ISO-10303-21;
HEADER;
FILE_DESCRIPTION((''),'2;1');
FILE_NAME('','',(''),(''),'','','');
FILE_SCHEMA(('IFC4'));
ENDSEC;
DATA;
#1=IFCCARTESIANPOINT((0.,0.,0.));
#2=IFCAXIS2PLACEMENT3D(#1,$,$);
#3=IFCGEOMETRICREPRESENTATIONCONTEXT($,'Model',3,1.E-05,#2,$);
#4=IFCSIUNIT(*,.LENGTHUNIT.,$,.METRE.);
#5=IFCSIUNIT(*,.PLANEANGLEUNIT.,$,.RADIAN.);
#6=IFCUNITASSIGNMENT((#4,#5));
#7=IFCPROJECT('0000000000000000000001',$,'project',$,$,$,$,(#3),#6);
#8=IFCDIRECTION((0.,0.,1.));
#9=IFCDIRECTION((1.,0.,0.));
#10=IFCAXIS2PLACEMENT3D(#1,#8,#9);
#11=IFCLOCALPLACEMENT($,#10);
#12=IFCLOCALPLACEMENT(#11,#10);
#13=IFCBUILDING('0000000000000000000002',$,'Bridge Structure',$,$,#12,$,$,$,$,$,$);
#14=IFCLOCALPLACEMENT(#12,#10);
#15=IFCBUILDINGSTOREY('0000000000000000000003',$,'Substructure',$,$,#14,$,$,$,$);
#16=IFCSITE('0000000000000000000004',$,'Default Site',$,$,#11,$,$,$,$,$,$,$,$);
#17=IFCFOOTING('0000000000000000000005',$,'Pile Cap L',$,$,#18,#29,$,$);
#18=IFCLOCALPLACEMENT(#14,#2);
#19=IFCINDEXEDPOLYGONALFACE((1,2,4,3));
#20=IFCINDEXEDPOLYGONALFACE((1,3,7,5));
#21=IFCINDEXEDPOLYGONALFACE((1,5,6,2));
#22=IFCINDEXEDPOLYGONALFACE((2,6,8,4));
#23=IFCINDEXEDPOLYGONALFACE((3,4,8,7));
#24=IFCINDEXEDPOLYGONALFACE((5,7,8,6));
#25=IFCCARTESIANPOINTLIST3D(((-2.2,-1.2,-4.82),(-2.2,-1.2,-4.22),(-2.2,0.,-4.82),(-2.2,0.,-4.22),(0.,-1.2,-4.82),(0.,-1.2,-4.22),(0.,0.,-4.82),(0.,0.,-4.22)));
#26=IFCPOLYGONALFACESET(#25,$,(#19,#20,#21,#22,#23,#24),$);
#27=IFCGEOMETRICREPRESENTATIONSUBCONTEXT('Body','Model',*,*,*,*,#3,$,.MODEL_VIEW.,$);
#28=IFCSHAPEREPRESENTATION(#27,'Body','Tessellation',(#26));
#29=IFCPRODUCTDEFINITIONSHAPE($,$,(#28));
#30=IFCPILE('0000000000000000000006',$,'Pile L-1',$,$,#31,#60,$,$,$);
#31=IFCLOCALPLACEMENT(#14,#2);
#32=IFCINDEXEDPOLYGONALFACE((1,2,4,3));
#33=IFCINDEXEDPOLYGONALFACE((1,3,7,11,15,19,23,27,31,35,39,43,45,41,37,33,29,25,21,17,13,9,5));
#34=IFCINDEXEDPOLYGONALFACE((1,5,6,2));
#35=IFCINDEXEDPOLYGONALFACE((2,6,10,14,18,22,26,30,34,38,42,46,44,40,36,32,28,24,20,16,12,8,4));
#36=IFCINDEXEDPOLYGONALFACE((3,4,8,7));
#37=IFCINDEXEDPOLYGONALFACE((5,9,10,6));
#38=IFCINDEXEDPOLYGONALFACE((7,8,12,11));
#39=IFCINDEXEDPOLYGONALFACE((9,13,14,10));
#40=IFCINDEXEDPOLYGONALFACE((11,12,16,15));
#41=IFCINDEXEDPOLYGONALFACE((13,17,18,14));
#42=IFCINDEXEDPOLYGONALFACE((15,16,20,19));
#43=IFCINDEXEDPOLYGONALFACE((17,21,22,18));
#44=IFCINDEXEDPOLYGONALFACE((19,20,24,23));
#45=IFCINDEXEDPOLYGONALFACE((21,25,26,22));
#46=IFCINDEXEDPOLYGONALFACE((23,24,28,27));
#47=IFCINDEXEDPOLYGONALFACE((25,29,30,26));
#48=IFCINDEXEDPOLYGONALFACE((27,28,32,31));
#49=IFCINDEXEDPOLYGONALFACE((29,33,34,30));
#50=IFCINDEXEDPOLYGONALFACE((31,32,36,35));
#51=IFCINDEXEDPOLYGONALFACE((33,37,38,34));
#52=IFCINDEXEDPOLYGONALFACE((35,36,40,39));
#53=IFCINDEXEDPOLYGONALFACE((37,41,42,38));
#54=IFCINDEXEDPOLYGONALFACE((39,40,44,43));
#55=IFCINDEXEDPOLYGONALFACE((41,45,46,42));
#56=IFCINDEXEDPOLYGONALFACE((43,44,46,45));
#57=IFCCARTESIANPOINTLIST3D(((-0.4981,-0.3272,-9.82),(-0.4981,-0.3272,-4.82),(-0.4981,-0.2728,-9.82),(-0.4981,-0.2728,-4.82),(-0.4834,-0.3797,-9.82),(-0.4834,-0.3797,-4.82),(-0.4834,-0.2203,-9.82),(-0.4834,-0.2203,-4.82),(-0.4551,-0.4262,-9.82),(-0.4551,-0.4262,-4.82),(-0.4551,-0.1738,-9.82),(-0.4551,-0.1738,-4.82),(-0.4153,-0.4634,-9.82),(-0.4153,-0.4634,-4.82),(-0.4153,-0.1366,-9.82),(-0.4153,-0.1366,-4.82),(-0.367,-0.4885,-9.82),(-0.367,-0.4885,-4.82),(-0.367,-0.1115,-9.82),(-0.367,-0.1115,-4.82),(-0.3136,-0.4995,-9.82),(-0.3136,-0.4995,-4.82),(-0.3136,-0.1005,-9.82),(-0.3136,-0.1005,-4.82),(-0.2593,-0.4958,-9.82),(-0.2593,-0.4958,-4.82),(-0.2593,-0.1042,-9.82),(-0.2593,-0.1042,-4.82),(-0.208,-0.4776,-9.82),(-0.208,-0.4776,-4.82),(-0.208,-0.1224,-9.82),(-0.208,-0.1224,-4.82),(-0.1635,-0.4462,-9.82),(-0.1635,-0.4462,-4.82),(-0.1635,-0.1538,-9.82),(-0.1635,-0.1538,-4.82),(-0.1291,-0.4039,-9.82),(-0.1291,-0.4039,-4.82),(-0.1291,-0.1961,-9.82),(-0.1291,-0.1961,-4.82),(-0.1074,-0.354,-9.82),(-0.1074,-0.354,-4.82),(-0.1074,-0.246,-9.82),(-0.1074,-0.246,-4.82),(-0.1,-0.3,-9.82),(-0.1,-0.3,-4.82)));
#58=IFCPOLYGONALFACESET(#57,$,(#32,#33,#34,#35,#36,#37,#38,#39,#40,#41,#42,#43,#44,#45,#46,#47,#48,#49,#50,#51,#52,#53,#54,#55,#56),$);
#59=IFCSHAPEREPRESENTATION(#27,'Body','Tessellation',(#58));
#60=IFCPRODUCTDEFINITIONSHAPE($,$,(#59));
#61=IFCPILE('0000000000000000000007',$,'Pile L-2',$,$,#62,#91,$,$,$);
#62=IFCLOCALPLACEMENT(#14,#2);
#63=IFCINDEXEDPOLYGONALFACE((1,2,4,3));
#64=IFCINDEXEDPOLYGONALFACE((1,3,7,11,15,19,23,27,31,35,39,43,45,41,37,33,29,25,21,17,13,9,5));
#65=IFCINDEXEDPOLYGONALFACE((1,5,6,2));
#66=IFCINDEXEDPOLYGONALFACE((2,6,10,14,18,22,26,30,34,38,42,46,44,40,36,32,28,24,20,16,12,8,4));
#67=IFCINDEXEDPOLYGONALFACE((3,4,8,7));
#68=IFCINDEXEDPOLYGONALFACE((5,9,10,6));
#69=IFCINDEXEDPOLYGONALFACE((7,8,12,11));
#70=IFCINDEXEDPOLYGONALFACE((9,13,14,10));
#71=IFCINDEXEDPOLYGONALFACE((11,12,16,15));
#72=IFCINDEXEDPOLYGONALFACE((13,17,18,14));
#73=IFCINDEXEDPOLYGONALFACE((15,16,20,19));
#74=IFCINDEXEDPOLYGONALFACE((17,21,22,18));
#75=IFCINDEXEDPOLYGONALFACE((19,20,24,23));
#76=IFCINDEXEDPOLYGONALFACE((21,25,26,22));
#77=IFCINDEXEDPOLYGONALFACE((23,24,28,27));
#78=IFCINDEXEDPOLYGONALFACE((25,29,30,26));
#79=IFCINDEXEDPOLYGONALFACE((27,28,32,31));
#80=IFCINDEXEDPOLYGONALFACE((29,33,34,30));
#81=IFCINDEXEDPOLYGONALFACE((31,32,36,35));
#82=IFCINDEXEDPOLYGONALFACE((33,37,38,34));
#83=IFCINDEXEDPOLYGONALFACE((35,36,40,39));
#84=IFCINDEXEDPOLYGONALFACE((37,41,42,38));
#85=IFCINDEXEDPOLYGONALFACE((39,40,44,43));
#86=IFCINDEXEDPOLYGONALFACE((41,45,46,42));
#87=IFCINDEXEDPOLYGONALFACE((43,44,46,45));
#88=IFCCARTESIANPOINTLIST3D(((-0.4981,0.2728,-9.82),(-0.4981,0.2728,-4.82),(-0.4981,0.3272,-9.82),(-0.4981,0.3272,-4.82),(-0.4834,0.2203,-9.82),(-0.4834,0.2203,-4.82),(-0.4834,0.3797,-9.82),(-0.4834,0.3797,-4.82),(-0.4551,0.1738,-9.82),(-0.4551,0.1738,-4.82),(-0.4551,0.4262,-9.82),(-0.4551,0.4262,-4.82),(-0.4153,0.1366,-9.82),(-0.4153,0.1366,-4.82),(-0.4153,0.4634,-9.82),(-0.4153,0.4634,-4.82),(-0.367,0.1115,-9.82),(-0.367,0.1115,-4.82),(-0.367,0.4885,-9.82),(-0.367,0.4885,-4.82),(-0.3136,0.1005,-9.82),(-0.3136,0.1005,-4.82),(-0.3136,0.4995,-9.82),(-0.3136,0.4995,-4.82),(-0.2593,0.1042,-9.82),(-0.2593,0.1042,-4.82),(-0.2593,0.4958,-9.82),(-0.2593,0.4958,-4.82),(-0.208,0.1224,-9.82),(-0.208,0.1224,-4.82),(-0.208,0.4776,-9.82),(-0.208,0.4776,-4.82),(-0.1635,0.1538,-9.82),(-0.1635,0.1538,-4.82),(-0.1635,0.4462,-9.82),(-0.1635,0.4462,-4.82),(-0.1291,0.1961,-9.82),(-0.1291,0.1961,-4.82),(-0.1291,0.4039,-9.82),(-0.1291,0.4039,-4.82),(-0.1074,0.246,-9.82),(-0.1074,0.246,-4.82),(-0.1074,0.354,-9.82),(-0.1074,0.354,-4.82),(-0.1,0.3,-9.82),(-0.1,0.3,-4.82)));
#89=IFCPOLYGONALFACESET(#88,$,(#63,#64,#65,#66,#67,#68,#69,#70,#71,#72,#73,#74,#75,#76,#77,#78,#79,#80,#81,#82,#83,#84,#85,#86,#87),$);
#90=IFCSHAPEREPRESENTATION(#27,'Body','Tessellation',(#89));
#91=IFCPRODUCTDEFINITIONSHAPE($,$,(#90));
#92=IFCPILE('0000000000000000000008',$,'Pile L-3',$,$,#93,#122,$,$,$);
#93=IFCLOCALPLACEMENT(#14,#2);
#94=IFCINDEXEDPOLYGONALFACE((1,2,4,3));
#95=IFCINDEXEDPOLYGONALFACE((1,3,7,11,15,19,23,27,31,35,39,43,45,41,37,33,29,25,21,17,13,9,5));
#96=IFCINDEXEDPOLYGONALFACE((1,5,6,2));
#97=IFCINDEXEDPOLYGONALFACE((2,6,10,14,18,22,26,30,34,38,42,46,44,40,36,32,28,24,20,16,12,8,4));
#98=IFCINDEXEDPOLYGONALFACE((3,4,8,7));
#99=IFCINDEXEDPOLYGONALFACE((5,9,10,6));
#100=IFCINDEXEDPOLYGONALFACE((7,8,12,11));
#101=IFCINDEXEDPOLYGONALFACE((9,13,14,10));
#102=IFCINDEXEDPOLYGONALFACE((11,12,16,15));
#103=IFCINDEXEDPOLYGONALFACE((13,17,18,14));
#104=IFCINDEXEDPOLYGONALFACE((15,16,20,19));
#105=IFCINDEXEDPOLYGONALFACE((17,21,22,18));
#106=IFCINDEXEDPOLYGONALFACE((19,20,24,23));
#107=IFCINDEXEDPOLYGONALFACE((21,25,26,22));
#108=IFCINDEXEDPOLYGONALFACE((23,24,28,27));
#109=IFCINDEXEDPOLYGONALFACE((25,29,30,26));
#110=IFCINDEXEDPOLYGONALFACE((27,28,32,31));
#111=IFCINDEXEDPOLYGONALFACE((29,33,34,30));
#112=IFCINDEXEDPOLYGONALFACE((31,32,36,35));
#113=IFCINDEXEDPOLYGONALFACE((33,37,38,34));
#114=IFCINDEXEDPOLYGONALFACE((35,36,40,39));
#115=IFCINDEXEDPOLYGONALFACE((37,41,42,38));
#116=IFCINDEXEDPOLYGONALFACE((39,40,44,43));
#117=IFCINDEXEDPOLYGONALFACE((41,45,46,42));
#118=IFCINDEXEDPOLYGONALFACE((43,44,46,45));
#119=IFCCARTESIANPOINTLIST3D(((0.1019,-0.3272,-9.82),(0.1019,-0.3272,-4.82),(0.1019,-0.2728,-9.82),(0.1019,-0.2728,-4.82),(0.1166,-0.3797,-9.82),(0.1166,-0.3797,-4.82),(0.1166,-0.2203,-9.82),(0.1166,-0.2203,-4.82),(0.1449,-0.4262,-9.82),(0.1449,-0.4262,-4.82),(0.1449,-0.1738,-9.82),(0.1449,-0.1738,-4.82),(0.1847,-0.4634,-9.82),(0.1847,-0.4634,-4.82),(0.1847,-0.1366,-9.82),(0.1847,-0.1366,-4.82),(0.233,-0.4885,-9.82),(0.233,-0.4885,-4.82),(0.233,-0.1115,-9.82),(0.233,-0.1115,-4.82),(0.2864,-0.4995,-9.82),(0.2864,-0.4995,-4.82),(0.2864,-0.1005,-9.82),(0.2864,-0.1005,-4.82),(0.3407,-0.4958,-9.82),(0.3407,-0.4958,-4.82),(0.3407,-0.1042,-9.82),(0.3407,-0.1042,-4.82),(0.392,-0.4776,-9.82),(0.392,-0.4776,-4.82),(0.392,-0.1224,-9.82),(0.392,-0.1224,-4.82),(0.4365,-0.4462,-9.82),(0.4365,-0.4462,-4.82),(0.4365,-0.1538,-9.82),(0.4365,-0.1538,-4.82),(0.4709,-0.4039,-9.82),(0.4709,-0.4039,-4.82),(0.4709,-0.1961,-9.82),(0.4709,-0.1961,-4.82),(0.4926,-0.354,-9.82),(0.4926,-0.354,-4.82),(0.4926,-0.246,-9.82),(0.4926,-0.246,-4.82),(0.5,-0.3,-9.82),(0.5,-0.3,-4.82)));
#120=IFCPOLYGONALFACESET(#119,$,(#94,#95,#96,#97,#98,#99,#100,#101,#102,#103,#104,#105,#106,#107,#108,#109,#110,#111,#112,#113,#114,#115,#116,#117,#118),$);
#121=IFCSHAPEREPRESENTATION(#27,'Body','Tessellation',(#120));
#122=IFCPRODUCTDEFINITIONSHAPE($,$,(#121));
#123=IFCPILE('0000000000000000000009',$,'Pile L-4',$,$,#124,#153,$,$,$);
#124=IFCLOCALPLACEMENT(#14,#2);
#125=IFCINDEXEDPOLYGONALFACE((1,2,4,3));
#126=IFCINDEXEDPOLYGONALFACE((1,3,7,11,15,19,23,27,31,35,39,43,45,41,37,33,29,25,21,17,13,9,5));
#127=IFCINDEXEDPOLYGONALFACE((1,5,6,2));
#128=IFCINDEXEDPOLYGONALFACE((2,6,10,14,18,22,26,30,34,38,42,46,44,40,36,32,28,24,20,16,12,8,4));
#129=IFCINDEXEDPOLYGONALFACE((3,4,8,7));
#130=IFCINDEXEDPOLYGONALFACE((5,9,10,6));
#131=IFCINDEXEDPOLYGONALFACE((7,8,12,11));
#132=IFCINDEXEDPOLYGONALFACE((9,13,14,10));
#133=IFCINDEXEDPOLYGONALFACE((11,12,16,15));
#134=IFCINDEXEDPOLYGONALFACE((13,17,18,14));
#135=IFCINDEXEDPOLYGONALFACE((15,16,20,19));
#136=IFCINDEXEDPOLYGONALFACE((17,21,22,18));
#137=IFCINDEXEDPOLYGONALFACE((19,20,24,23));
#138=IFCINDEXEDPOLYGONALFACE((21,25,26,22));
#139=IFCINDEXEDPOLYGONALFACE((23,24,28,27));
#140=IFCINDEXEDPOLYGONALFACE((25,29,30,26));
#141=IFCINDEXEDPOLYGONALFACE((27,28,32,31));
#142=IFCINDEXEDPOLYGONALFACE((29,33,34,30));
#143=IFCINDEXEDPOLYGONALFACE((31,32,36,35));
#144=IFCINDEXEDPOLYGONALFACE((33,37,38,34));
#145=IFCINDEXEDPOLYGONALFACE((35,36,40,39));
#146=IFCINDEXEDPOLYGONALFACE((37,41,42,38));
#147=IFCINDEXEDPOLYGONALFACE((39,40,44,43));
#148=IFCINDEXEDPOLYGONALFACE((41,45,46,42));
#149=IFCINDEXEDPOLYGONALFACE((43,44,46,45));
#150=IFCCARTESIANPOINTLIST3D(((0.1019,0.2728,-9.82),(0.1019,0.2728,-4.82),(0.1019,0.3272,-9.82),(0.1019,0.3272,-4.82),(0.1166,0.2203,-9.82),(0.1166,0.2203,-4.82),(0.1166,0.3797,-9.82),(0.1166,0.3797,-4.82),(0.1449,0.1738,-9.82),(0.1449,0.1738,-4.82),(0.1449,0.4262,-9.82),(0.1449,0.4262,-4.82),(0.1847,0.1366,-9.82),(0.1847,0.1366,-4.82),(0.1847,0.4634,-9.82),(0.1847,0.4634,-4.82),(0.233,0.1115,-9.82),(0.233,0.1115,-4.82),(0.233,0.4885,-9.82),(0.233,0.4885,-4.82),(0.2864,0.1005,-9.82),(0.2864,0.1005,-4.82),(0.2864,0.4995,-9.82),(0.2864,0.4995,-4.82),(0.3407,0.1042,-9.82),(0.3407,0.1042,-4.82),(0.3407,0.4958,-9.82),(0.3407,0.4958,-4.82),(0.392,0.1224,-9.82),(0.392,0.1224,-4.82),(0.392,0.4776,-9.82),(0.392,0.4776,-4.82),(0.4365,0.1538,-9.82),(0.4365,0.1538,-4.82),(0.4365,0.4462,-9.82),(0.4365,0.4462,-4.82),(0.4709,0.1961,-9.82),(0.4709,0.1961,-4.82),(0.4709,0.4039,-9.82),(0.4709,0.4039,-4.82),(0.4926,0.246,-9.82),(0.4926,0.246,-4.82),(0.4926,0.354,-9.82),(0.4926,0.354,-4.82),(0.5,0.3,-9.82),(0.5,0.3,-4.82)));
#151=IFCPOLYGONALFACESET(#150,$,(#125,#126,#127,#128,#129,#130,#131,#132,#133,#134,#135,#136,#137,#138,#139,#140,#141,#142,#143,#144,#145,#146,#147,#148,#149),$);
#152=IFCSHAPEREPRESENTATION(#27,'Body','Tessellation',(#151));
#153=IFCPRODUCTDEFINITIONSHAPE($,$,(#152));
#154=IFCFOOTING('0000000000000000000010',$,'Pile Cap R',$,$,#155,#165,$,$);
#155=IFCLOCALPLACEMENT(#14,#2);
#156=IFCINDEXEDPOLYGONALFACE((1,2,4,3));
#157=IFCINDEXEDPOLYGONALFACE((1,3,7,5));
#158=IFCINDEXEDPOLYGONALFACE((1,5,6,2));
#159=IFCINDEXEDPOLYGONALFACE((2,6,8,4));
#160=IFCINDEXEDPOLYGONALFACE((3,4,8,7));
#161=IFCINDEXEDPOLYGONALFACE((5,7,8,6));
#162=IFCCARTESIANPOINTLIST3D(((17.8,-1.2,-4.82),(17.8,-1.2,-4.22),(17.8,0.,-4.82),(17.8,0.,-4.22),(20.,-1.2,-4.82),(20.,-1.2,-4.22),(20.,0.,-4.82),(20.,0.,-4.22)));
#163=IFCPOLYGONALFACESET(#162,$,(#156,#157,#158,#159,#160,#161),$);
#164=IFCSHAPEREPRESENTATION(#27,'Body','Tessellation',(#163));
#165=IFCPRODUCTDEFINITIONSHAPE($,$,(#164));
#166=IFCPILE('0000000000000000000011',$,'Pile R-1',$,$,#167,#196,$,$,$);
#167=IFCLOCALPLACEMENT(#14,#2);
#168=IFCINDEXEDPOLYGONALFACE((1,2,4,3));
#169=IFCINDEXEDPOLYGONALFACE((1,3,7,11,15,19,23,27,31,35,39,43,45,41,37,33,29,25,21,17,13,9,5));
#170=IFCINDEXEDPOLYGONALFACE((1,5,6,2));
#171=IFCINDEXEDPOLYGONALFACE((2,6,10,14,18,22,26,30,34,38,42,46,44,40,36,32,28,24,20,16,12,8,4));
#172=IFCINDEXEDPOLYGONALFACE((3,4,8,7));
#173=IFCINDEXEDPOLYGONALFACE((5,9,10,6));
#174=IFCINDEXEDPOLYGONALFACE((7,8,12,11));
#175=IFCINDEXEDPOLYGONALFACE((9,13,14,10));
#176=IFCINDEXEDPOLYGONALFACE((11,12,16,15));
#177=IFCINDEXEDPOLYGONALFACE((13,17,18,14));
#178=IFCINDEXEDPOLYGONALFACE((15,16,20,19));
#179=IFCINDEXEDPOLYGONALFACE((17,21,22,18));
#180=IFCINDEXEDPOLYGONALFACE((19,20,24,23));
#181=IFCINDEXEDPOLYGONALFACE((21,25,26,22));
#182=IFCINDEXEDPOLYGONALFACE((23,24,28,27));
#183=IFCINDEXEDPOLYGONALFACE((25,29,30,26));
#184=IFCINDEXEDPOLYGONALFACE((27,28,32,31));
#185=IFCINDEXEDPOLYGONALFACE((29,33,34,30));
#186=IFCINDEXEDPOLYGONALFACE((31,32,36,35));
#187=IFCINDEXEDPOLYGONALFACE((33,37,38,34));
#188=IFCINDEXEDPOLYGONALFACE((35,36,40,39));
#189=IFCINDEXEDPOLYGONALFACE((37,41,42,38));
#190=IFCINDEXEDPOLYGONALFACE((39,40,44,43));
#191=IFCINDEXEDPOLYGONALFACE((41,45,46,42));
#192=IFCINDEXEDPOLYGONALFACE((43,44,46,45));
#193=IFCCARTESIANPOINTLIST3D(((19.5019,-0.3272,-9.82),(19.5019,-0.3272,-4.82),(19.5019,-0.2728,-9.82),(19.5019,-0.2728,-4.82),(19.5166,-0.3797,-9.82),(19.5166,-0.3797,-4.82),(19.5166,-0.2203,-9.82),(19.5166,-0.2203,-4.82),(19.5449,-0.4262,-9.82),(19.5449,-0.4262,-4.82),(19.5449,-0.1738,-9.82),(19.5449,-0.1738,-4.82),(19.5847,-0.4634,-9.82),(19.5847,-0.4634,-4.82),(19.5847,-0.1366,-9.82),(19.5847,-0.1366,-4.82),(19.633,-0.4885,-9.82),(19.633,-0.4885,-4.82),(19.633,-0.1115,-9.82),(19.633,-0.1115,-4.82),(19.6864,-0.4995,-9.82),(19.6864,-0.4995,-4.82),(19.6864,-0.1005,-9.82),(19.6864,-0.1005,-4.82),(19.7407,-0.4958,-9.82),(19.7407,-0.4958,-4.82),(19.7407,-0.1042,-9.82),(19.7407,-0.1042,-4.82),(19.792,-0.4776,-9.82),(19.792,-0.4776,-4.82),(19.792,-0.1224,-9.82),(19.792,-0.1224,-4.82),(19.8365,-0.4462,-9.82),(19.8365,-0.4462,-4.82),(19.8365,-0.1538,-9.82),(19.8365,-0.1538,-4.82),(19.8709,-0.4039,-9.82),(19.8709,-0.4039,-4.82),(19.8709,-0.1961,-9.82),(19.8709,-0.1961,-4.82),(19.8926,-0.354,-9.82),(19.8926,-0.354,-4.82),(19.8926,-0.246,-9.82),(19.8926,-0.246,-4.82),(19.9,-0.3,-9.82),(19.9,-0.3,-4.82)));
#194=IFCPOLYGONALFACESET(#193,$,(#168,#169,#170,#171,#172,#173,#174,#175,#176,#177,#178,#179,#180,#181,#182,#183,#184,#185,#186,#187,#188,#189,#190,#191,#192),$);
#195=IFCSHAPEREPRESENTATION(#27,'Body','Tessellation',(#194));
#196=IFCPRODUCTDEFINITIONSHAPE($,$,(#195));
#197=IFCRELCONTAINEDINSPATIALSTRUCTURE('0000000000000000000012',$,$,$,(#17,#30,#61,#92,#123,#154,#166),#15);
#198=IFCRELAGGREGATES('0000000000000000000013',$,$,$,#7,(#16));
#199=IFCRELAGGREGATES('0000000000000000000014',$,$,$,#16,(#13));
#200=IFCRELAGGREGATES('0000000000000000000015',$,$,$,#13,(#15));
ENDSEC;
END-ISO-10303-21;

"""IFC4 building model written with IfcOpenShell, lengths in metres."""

from ifc_helpers import new_model, si_unit, frame, origin, origin_with_axes, origin_2d_with_axis, place, context, subcontext, project, spatial, rectangle, circle, extrude, element, save


model = new_model("IFC4")

# Units and contexts
model_context = context("Model", 3, precision=1e-05, world=origin())
body_context = subcontext(model_context, "Body", "Model", "MODEL_VIEW")
ifc_project = project(units=[si_unit("LENGTHUNIT", "METRE"), si_unit("PLANEANGLEUNIT", "RADIAN")], contexts=[model_context])

# Site, building, storey
site_placement = place(None, origin_with_axes())
site = spatial("IfcSite", under=ifc_project, at=site_placement, Name="Default Site")
building_placement = place(site_placement, origin_with_axes())
building = spatial("IfcBuilding", under=site, at=building_placement, Name="Bridge Structure")
storey_placement = place(building_placement, origin_with_axes())
storey = spatial("IfcBuildingStorey", under=building, at=storey_placement, Name="Substructure")

# Footing
footing_1_placement = place(storey_placement, frame((-1.1, -0.6, -4.82), z_axis=(0.0, 0.0, 1.0), x_axis=(1.0, 0.0, 0.0)))
element("IfcFooting", 1, at=footing_1_placement, inside=storey, Name="Pile Cap L", context=body_context, shape_type="SweptSolid", body=[
    extrude(rectangle(XDim=2.2, YDim=1.2, at=origin_2d_with_axis()), origin_with_axes(), (0.0, 0.0, 1.0), 0.6),
])

# Piles
for number, where, z_axis, x_axis, name in (
    (2, (-0.3, -0.3, -9.82), (0.0, 0.0, 1.0), (1.0, 0.0, 0.0), "Pile L-1"),
    (3, (-0.3, 0.3, -9.82), (0.0, 0.0, 1.0), (1.0, 0.0, 0.0), "Pile L-2"),
    (4, (0.3, -0.3, -9.82), (0.0, 0.0, 1.0), (1.0, 0.0, 0.0), "Pile L-3"),
    (5, (0.3, 0.3, -9.82), (0.0, 0.0, 1.0), (1.0, 0.0, 0.0), "Pile L-4"),
):
    element("IfcPile", number, at=place(storey_placement, frame(where, z_axis=z_axis, x_axis=x_axis)), inside=storey, Name=name, context=body_context, shape_type="SweptSolid", body=[
        extrude(circle(Radius=0.2, at=origin_2d_with_axis()), origin_with_axes(), (0.0, 0.0, 1.0), 5.0),
    ])

# Footing
footing_2_placement = place(storey_placement, frame((18.9, -0.6, -4.82), z_axis=(0.0, 0.0, 1.0), x_axis=(1.0, 0.0, 0.0)))
element("IfcFooting", 6, at=footing_2_placement, inside=storey, Name="Pile Cap R", context=body_context, shape_type="SweptSolid", body=[
    extrude(rectangle(XDim=2.2, YDim=1.2, at=origin_2d_with_axis()), origin_with_axes(), (0.0, 0.0, 1.0), 0.6),
])

# Pile
for number, where, z_axis, x_axis, name in (
    (7, (19.7, -0.3, -9.82), (0.0, 0.0, 1.0), (1.0, 0.0, 0.0), "Pile R-1"),
):
    element("IfcPile", number, at=place(storey_placement, frame(where, z_axis=z_axis, x_axis=x_axis)), inside=storey, Name=name, context=body_context, shape_type="SweptSolid", body=[
        extrude(circle(Radius=0.2, at=origin_2d_with_axis()), origin_with_axes(), (0.0, 0.0, 1.0), 5.0),
    ])

save(model, "model.ifc")
